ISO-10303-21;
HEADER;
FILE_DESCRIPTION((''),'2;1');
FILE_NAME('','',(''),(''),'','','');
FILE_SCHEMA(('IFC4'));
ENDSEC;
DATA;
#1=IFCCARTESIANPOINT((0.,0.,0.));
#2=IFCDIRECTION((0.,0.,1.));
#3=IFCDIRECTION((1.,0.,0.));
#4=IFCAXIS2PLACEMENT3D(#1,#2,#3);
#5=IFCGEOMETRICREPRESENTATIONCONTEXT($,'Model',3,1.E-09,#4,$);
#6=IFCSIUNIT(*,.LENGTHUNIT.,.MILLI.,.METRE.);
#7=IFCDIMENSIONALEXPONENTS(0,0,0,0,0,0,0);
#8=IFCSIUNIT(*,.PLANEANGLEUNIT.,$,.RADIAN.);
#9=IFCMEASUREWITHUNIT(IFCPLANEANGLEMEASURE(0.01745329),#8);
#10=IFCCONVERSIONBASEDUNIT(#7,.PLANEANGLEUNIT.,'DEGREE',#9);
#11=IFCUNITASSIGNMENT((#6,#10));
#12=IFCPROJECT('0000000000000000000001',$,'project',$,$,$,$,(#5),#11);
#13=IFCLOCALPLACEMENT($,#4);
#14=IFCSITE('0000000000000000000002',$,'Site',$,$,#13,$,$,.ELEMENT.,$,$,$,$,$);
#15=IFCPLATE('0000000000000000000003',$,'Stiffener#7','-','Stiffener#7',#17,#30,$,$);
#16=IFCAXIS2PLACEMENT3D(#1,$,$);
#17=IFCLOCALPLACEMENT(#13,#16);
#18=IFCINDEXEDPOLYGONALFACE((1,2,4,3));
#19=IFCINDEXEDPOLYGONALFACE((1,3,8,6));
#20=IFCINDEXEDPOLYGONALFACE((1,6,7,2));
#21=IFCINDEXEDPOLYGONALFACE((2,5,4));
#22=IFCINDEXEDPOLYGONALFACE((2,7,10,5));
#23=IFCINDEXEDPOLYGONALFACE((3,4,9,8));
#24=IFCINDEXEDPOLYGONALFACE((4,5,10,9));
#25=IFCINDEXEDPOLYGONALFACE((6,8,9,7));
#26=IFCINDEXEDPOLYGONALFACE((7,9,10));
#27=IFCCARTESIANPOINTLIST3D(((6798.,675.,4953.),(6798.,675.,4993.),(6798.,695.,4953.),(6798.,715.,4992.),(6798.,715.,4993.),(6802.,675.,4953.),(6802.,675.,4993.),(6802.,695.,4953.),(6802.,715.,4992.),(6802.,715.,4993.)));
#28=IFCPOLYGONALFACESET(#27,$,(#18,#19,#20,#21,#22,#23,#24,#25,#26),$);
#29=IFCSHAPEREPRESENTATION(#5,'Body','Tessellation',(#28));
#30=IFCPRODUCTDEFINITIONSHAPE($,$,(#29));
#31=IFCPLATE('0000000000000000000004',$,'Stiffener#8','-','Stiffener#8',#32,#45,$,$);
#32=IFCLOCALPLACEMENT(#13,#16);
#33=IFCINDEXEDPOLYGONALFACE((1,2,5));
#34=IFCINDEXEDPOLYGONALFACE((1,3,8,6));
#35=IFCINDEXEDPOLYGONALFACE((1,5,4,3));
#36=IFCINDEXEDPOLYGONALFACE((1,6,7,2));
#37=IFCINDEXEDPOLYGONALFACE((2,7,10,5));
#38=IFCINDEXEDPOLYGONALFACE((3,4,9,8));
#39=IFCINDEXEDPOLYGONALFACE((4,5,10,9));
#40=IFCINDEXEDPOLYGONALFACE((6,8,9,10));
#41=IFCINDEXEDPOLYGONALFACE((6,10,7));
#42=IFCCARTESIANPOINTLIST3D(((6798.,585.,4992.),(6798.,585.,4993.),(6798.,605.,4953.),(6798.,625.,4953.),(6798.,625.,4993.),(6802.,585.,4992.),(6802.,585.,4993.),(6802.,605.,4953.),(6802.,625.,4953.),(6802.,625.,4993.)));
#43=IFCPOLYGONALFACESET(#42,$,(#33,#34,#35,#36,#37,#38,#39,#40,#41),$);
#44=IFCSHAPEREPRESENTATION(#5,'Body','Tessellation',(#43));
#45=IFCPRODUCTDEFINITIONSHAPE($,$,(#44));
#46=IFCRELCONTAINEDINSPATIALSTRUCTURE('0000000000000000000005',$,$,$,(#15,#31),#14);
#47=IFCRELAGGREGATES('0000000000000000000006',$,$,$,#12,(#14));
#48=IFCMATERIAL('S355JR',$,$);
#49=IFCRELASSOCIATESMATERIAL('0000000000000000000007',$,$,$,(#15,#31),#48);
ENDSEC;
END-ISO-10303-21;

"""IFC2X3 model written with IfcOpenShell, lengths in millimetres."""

from ifc_helpers import new_model, entity, si_unit, converted_unit, frame, origin, origin_with_axes, place, context, project, spatial, polyline, outline, extrude, material, element, save


model = new_model("IFC2X3")

# Units and contexts
model_context = context("Model", 3, precision=1e-09, world=origin_with_axes())
ifc_project = project(units=[si_unit("LENGTHUNIT", "METRE", prefix="MILLI"), converted_unit("PLANEANGLEUNIT", "DEGREE", entity("IfcPlaneAngleMeasure", 0.01745329), si_unit("PLANEANGLEUNIT", "RADIAN"), dimensions=[0, 0, 0, 0, 0, 0, 0])], contexts=[model_context])

# Site
site_placement = place(None, origin_with_axes())
site = spatial("IfcSite", under=ifc_project, at=site_placement, Name="Site", CompositionType="ELEMENT")

# Shared definitions
ifc_material = material(Name="S355JR")

# Plates, openings
plate_1_placement = place(None, frame((6798.0, 675.0, 4993.0), z_axis=(1.0, 0.0, 0.0), x_axis=(0.0, 0.0, -1.0)))
plate_1 = element("IfcPlate", 1, at=plate_1_placement, inside=site, material=ifc_material, Name="Stiffener#7", Description="-", ObjectType="Stiffener#7", context=model_context, shape_type="SweptSolid", body=[
    extrude(outline(polyline([(0.0, 0.0), (40.0, 0.0), (40.0, 40.0), (0.0, 40.0), (0.0, 0.0)])), origin_with_axes(), (0.0, 0.0, 1.0), 4.0),
])
opening_1_placement = place(plate_1_placement, frame((0.0, 0.0, 0.0), z_axis=(0.0, 0.0, 1.0), x_axis=(1.0, 0.0, 0.0)))
element("IfcOpeningElement", 2, at=opening_1_placement, cuts=plate_1, ObjectType="Opening", context=model_context, shape_type="SweptSolid", body=[
    extrude(outline(polyline([(40.0, 40.0), (1.0, 40.0), (40.0, 20.0), (40.0, 40.0)])), origin(), (0.0, 0.0, 1.0), 4.0),
])
plate_2_placement = place(None, frame((6798.0, 625.0, 4993.0), z_axis=(1.0, 0.0, 0.0), x_axis=(0.0, -1.0, 0.0)))
plate_2 = element("IfcPlate", 3, at=plate_2_placement, inside=site, material=ifc_material, Name="Stiffener#8", Description="-", ObjectType="Stiffener#8", context=model_context, shape_type="SweptSolid", body=[
    extrude(outline(polyline([(0.0, 0.0), (40.0, 0.0), (40.0, 40.0), (0.0, 40.0), (0.0, 0.0)])), origin_with_axes(), (0.0, 0.0, 1.0), 4.0),
])
opening_2_placement = place(plate_2_placement, frame((0.0, 0.0, 0.0), z_axis=(0.0, 0.0, 1.0), x_axis=(1.0, 0.0, 0.0)))
element("IfcOpeningElement", 4, at=opening_2_placement, cuts=plate_2, ObjectType="Opening", context=model_context, shape_type="SweptSolid", body=[
    extrude(outline(polyline([(40.0, 40.0), (20.0, 40.0), (40.0, 1.0), (40.0, 40.0)])), origin(), (0.0, 0.0, 1.0), 4.0),
])

save(model, "model.ifc")
